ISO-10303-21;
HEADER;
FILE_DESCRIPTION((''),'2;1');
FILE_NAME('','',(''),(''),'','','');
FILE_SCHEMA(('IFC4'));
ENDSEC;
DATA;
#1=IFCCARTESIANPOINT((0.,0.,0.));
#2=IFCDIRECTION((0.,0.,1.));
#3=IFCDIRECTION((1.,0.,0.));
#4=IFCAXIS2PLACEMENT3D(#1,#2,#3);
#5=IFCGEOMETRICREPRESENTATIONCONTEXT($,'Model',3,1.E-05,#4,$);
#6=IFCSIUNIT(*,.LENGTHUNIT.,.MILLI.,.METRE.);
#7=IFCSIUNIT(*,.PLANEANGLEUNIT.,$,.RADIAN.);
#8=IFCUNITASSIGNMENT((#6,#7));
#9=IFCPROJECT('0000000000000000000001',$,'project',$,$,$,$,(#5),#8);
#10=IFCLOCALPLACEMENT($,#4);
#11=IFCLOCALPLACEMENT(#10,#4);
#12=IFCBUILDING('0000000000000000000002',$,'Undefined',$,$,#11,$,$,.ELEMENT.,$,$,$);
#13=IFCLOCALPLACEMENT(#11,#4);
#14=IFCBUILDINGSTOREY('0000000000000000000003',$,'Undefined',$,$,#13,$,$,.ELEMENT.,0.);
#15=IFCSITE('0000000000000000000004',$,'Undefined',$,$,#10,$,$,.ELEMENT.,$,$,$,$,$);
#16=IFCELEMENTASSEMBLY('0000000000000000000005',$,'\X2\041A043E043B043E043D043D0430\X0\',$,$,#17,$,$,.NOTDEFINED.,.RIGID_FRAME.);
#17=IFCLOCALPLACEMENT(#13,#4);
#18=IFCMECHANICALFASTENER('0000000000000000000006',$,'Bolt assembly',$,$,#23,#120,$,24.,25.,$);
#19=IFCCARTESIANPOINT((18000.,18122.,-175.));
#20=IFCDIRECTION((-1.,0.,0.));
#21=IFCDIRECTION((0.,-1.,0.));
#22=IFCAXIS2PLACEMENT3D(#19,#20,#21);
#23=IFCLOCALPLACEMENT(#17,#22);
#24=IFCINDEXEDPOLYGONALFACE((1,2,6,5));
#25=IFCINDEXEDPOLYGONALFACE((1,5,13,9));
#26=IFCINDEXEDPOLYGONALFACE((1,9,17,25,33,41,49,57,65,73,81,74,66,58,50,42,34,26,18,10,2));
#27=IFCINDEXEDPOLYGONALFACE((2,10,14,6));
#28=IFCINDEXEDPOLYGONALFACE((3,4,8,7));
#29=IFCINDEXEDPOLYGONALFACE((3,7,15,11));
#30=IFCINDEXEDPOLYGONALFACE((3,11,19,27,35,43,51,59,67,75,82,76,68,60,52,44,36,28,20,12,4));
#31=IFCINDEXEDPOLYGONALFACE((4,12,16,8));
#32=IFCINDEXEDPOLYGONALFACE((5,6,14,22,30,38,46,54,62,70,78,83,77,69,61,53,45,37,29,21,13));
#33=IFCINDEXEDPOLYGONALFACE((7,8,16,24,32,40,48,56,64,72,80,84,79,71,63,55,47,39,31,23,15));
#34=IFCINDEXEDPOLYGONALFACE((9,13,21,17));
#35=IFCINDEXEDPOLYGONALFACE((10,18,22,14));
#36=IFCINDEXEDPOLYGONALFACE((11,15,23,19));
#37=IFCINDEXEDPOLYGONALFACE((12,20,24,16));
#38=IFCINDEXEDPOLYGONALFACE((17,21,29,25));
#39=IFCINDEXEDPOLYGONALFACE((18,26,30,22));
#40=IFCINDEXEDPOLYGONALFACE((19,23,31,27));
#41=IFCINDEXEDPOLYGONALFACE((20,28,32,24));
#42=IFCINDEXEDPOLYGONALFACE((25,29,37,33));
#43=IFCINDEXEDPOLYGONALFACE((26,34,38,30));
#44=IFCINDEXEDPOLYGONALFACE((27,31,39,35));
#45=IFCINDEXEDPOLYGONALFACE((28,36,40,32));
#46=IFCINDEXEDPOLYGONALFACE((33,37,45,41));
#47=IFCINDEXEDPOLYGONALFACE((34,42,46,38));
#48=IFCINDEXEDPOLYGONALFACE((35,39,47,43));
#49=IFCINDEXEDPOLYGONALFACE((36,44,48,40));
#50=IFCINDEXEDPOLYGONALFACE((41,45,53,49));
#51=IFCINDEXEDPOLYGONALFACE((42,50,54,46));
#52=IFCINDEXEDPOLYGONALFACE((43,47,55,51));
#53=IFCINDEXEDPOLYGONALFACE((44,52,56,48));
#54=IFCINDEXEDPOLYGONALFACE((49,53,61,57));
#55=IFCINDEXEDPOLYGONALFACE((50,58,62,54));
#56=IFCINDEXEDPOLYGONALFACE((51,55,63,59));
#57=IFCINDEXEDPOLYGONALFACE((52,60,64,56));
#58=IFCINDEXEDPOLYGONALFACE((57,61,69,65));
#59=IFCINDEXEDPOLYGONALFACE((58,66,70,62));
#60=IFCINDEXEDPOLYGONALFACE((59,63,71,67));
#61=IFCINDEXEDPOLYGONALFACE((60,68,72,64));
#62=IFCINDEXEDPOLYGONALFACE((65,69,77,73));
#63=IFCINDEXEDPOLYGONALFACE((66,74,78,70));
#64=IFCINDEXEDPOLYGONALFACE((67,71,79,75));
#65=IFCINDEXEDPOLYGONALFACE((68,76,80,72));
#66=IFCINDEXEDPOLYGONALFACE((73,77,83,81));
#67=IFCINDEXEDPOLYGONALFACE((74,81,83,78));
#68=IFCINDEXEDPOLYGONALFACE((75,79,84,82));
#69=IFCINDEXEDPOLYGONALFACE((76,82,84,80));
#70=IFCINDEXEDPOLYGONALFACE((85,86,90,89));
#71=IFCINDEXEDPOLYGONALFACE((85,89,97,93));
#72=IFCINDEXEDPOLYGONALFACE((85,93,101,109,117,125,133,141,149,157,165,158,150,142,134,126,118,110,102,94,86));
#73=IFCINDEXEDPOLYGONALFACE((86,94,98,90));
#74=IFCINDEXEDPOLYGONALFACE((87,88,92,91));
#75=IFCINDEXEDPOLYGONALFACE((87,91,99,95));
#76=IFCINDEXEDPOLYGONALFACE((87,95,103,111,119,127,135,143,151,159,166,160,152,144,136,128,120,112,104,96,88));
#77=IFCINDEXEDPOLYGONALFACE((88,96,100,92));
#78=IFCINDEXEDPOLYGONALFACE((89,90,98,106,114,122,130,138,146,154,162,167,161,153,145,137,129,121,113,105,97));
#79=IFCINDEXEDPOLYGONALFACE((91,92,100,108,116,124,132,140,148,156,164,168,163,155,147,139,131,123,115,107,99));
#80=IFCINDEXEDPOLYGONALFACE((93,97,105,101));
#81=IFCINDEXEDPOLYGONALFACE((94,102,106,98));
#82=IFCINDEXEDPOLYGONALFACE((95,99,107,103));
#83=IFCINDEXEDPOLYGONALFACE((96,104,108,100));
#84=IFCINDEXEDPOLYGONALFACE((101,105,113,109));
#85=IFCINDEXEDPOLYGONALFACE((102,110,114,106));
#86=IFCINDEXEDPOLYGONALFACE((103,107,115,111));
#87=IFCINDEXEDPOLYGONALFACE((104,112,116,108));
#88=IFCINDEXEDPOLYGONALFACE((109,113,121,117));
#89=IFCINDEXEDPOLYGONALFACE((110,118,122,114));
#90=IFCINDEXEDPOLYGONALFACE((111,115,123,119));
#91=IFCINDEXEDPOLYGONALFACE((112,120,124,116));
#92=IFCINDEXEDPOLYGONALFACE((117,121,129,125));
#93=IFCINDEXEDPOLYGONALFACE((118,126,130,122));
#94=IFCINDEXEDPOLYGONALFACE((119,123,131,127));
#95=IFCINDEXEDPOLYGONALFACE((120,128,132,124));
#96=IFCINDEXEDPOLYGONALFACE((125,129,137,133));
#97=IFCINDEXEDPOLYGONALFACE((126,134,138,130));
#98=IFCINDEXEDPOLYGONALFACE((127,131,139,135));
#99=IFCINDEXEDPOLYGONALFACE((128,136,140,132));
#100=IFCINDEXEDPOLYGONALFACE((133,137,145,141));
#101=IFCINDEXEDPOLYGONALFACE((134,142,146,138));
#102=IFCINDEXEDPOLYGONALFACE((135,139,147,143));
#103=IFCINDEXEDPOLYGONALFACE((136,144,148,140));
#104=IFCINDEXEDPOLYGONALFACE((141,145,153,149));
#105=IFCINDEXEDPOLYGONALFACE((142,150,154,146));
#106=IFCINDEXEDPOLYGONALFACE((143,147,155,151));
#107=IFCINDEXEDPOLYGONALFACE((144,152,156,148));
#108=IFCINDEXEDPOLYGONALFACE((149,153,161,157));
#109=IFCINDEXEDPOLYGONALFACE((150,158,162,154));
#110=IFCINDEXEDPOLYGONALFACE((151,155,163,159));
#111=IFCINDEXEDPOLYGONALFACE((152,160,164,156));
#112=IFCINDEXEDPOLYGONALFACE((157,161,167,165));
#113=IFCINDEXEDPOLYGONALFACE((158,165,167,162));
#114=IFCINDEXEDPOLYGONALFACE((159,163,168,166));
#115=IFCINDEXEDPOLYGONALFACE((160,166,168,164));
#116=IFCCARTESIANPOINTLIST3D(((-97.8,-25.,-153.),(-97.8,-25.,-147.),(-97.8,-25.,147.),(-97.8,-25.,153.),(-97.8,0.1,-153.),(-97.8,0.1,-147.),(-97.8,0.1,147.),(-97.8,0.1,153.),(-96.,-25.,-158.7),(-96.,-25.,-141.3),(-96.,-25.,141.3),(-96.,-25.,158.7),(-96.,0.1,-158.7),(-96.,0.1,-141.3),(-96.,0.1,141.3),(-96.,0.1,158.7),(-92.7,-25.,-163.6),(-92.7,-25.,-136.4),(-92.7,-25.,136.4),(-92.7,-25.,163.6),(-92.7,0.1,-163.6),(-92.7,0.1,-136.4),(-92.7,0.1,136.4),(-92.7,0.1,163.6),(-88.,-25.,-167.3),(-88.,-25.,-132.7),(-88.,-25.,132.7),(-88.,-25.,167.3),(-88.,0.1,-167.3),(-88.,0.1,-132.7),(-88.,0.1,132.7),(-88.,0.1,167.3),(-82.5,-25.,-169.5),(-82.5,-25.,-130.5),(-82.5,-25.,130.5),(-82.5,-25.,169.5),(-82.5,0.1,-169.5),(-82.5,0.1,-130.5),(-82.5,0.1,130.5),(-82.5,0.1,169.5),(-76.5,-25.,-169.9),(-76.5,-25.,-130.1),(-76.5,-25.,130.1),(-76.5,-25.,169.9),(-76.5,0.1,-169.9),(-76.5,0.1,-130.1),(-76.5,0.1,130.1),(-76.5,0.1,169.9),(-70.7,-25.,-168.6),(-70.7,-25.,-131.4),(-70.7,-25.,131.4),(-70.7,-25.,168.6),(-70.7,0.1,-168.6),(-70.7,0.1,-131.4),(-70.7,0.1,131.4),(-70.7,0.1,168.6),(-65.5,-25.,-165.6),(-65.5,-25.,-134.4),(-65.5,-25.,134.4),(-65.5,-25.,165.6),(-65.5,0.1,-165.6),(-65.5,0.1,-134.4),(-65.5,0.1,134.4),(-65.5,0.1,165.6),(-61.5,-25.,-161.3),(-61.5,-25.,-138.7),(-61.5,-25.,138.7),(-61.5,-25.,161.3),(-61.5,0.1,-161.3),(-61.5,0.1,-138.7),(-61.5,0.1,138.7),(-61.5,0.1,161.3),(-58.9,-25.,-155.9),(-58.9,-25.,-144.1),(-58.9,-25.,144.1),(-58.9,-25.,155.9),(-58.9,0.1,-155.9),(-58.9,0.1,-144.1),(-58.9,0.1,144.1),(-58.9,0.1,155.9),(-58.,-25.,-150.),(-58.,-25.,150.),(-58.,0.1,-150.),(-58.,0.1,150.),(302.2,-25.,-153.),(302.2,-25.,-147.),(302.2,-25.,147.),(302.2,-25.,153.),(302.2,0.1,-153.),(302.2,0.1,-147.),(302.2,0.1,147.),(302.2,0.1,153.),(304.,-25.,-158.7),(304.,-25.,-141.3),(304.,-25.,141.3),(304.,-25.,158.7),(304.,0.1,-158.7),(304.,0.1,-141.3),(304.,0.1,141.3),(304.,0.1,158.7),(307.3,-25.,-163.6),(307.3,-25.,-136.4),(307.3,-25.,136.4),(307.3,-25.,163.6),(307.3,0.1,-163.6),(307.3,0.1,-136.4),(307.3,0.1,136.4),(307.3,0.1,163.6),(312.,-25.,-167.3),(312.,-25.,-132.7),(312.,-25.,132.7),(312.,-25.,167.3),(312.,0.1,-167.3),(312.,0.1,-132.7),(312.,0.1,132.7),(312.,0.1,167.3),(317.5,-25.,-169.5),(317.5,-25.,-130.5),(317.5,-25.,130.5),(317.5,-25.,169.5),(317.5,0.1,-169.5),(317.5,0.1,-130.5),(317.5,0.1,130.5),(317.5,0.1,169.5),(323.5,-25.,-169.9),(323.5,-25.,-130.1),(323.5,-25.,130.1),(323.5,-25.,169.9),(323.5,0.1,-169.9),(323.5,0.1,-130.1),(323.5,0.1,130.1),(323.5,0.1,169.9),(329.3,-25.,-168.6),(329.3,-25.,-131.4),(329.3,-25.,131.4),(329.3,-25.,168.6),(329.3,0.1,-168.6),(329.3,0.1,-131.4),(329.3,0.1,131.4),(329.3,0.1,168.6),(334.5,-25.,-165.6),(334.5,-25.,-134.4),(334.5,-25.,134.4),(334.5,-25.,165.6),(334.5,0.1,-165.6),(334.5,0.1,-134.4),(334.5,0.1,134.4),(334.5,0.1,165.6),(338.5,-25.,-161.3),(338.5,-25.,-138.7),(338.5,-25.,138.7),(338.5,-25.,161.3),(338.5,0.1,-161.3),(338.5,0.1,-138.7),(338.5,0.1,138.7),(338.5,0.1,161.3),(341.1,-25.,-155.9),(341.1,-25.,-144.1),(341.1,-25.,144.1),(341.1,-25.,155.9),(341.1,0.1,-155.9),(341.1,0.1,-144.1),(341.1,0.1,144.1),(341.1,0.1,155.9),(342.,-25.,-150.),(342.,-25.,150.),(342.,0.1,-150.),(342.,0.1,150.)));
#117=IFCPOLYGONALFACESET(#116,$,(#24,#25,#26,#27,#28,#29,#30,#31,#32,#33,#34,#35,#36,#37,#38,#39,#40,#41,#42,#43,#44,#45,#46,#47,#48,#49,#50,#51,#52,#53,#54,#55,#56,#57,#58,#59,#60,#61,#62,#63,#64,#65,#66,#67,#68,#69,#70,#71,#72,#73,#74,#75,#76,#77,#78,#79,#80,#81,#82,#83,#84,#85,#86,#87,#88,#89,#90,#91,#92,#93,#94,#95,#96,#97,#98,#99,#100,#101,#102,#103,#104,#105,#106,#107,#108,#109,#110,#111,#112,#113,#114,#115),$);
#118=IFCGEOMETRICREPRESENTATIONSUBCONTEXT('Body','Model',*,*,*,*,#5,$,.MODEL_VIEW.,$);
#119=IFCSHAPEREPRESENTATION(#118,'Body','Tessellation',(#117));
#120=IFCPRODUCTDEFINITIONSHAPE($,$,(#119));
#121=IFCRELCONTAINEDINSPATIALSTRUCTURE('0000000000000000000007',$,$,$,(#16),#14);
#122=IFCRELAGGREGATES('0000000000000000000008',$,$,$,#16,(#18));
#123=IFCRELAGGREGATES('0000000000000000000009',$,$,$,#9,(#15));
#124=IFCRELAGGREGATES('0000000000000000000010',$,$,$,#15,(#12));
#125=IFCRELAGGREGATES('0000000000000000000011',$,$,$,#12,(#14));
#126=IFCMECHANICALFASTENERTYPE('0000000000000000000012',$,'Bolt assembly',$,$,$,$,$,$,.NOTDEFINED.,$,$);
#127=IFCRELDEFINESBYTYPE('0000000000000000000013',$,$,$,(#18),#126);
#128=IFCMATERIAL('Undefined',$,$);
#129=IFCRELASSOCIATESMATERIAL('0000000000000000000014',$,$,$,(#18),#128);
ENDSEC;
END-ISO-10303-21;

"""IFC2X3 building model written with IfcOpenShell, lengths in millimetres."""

from ifc_helpers import new_model, si_unit, frame, origin_with_axes, origin_2d_with_axis, place, context, subcontext, project, spatial, circle, extrude, source, transform, mapped, material, type_object, element, aggregate, save


model = new_model("IFC2X3")

# Units and contexts
model_context = context("Model", 3, precision=1e-05, world=origin_with_axes())
body_context = subcontext(model_context, "Body", "Model", "MODEL_VIEW")
ifc_project = project(units=[si_unit("LENGTHUNIT", "METRE", prefix="MILLI"), si_unit("PLANEANGLEUNIT", "RADIAN")], contexts=[model_context])

# Site, building, storey
site_placement = place(None, origin_with_axes())
site = spatial("IfcSite", under=ifc_project, at=site_placement, Name="Undefined", CompositionType="ELEMENT")
building_placement = place(site_placement, origin_with_axes())
building = spatial("IfcBuilding", under=site, at=building_placement, Name="Undefined", CompositionType="ELEMENT")
storey_placement = place(building_placement, origin_with_axes())
storey = spatial("IfcBuildingStorey", under=building, at=storey_placement, Name="Undefined", CompositionType="ELEMENT", Elevation=0.0)

# Element assembly
assembly_1_placement = place(storey_placement, origin_with_axes())
assembly_1 = element("IfcElementAssembly", 1, at=assembly_1_placement, inside=storey, Name="Колонна", AssemblyPlace="NOTDEFINED", PredefinedType="RIGID_FRAME")

# Mechanical fastener
ifc_material_1 = material(Name="Undefined")
mechanical_fastener_type = type_object("IfcMechanicalFastenerType", Name="Bolt assembly")
shared_shape_1 = source(origin_with_axes(), body_context, "Body", "SweptSolid", [
    extrude(circle(Radius=20.0, at=origin_2d_with_axis()), frame((0.0, -25.0, 0.0), z_axis=(0.0, 1.0, 0.0), x_axis=(1.0, 0.0, 0.0)), (0.0, 0.0, 1.0), 25.1),
])
mechanical_fastener_1_placement = place(assembly_1_placement, frame((18000.0, 18122.0, -175.0), z_axis=(-1.0, 0.0, 0.0), x_axis=(0.0, -1.0, 0.0)))
mechanical_fastener_1 = element("IfcMechanicalFastener", 2, at=mechanical_fastener_1_placement, type_object=mechanical_fastener_type, material=ifc_material_1, Name="Bolt assembly", NominalDiameter=24.0, NominalLength=25.0, context=body_context, shape_type="MappedRepresentation", body=[
    mapped(shared_shape_1, transform((-78.0, 0.0, -150.0))),
    mapped(shared_shape_1, transform((-78.0, 0.0, 150.0))),
    mapped(shared_shape_1, transform((322.0, 0.0, -150.0))),
    mapped(shared_shape_1, transform((322.0, 0.0, 150.0))),
])
aggregate(assembly_1, [mechanical_fastener_1])

save(model, "model.ifc")
